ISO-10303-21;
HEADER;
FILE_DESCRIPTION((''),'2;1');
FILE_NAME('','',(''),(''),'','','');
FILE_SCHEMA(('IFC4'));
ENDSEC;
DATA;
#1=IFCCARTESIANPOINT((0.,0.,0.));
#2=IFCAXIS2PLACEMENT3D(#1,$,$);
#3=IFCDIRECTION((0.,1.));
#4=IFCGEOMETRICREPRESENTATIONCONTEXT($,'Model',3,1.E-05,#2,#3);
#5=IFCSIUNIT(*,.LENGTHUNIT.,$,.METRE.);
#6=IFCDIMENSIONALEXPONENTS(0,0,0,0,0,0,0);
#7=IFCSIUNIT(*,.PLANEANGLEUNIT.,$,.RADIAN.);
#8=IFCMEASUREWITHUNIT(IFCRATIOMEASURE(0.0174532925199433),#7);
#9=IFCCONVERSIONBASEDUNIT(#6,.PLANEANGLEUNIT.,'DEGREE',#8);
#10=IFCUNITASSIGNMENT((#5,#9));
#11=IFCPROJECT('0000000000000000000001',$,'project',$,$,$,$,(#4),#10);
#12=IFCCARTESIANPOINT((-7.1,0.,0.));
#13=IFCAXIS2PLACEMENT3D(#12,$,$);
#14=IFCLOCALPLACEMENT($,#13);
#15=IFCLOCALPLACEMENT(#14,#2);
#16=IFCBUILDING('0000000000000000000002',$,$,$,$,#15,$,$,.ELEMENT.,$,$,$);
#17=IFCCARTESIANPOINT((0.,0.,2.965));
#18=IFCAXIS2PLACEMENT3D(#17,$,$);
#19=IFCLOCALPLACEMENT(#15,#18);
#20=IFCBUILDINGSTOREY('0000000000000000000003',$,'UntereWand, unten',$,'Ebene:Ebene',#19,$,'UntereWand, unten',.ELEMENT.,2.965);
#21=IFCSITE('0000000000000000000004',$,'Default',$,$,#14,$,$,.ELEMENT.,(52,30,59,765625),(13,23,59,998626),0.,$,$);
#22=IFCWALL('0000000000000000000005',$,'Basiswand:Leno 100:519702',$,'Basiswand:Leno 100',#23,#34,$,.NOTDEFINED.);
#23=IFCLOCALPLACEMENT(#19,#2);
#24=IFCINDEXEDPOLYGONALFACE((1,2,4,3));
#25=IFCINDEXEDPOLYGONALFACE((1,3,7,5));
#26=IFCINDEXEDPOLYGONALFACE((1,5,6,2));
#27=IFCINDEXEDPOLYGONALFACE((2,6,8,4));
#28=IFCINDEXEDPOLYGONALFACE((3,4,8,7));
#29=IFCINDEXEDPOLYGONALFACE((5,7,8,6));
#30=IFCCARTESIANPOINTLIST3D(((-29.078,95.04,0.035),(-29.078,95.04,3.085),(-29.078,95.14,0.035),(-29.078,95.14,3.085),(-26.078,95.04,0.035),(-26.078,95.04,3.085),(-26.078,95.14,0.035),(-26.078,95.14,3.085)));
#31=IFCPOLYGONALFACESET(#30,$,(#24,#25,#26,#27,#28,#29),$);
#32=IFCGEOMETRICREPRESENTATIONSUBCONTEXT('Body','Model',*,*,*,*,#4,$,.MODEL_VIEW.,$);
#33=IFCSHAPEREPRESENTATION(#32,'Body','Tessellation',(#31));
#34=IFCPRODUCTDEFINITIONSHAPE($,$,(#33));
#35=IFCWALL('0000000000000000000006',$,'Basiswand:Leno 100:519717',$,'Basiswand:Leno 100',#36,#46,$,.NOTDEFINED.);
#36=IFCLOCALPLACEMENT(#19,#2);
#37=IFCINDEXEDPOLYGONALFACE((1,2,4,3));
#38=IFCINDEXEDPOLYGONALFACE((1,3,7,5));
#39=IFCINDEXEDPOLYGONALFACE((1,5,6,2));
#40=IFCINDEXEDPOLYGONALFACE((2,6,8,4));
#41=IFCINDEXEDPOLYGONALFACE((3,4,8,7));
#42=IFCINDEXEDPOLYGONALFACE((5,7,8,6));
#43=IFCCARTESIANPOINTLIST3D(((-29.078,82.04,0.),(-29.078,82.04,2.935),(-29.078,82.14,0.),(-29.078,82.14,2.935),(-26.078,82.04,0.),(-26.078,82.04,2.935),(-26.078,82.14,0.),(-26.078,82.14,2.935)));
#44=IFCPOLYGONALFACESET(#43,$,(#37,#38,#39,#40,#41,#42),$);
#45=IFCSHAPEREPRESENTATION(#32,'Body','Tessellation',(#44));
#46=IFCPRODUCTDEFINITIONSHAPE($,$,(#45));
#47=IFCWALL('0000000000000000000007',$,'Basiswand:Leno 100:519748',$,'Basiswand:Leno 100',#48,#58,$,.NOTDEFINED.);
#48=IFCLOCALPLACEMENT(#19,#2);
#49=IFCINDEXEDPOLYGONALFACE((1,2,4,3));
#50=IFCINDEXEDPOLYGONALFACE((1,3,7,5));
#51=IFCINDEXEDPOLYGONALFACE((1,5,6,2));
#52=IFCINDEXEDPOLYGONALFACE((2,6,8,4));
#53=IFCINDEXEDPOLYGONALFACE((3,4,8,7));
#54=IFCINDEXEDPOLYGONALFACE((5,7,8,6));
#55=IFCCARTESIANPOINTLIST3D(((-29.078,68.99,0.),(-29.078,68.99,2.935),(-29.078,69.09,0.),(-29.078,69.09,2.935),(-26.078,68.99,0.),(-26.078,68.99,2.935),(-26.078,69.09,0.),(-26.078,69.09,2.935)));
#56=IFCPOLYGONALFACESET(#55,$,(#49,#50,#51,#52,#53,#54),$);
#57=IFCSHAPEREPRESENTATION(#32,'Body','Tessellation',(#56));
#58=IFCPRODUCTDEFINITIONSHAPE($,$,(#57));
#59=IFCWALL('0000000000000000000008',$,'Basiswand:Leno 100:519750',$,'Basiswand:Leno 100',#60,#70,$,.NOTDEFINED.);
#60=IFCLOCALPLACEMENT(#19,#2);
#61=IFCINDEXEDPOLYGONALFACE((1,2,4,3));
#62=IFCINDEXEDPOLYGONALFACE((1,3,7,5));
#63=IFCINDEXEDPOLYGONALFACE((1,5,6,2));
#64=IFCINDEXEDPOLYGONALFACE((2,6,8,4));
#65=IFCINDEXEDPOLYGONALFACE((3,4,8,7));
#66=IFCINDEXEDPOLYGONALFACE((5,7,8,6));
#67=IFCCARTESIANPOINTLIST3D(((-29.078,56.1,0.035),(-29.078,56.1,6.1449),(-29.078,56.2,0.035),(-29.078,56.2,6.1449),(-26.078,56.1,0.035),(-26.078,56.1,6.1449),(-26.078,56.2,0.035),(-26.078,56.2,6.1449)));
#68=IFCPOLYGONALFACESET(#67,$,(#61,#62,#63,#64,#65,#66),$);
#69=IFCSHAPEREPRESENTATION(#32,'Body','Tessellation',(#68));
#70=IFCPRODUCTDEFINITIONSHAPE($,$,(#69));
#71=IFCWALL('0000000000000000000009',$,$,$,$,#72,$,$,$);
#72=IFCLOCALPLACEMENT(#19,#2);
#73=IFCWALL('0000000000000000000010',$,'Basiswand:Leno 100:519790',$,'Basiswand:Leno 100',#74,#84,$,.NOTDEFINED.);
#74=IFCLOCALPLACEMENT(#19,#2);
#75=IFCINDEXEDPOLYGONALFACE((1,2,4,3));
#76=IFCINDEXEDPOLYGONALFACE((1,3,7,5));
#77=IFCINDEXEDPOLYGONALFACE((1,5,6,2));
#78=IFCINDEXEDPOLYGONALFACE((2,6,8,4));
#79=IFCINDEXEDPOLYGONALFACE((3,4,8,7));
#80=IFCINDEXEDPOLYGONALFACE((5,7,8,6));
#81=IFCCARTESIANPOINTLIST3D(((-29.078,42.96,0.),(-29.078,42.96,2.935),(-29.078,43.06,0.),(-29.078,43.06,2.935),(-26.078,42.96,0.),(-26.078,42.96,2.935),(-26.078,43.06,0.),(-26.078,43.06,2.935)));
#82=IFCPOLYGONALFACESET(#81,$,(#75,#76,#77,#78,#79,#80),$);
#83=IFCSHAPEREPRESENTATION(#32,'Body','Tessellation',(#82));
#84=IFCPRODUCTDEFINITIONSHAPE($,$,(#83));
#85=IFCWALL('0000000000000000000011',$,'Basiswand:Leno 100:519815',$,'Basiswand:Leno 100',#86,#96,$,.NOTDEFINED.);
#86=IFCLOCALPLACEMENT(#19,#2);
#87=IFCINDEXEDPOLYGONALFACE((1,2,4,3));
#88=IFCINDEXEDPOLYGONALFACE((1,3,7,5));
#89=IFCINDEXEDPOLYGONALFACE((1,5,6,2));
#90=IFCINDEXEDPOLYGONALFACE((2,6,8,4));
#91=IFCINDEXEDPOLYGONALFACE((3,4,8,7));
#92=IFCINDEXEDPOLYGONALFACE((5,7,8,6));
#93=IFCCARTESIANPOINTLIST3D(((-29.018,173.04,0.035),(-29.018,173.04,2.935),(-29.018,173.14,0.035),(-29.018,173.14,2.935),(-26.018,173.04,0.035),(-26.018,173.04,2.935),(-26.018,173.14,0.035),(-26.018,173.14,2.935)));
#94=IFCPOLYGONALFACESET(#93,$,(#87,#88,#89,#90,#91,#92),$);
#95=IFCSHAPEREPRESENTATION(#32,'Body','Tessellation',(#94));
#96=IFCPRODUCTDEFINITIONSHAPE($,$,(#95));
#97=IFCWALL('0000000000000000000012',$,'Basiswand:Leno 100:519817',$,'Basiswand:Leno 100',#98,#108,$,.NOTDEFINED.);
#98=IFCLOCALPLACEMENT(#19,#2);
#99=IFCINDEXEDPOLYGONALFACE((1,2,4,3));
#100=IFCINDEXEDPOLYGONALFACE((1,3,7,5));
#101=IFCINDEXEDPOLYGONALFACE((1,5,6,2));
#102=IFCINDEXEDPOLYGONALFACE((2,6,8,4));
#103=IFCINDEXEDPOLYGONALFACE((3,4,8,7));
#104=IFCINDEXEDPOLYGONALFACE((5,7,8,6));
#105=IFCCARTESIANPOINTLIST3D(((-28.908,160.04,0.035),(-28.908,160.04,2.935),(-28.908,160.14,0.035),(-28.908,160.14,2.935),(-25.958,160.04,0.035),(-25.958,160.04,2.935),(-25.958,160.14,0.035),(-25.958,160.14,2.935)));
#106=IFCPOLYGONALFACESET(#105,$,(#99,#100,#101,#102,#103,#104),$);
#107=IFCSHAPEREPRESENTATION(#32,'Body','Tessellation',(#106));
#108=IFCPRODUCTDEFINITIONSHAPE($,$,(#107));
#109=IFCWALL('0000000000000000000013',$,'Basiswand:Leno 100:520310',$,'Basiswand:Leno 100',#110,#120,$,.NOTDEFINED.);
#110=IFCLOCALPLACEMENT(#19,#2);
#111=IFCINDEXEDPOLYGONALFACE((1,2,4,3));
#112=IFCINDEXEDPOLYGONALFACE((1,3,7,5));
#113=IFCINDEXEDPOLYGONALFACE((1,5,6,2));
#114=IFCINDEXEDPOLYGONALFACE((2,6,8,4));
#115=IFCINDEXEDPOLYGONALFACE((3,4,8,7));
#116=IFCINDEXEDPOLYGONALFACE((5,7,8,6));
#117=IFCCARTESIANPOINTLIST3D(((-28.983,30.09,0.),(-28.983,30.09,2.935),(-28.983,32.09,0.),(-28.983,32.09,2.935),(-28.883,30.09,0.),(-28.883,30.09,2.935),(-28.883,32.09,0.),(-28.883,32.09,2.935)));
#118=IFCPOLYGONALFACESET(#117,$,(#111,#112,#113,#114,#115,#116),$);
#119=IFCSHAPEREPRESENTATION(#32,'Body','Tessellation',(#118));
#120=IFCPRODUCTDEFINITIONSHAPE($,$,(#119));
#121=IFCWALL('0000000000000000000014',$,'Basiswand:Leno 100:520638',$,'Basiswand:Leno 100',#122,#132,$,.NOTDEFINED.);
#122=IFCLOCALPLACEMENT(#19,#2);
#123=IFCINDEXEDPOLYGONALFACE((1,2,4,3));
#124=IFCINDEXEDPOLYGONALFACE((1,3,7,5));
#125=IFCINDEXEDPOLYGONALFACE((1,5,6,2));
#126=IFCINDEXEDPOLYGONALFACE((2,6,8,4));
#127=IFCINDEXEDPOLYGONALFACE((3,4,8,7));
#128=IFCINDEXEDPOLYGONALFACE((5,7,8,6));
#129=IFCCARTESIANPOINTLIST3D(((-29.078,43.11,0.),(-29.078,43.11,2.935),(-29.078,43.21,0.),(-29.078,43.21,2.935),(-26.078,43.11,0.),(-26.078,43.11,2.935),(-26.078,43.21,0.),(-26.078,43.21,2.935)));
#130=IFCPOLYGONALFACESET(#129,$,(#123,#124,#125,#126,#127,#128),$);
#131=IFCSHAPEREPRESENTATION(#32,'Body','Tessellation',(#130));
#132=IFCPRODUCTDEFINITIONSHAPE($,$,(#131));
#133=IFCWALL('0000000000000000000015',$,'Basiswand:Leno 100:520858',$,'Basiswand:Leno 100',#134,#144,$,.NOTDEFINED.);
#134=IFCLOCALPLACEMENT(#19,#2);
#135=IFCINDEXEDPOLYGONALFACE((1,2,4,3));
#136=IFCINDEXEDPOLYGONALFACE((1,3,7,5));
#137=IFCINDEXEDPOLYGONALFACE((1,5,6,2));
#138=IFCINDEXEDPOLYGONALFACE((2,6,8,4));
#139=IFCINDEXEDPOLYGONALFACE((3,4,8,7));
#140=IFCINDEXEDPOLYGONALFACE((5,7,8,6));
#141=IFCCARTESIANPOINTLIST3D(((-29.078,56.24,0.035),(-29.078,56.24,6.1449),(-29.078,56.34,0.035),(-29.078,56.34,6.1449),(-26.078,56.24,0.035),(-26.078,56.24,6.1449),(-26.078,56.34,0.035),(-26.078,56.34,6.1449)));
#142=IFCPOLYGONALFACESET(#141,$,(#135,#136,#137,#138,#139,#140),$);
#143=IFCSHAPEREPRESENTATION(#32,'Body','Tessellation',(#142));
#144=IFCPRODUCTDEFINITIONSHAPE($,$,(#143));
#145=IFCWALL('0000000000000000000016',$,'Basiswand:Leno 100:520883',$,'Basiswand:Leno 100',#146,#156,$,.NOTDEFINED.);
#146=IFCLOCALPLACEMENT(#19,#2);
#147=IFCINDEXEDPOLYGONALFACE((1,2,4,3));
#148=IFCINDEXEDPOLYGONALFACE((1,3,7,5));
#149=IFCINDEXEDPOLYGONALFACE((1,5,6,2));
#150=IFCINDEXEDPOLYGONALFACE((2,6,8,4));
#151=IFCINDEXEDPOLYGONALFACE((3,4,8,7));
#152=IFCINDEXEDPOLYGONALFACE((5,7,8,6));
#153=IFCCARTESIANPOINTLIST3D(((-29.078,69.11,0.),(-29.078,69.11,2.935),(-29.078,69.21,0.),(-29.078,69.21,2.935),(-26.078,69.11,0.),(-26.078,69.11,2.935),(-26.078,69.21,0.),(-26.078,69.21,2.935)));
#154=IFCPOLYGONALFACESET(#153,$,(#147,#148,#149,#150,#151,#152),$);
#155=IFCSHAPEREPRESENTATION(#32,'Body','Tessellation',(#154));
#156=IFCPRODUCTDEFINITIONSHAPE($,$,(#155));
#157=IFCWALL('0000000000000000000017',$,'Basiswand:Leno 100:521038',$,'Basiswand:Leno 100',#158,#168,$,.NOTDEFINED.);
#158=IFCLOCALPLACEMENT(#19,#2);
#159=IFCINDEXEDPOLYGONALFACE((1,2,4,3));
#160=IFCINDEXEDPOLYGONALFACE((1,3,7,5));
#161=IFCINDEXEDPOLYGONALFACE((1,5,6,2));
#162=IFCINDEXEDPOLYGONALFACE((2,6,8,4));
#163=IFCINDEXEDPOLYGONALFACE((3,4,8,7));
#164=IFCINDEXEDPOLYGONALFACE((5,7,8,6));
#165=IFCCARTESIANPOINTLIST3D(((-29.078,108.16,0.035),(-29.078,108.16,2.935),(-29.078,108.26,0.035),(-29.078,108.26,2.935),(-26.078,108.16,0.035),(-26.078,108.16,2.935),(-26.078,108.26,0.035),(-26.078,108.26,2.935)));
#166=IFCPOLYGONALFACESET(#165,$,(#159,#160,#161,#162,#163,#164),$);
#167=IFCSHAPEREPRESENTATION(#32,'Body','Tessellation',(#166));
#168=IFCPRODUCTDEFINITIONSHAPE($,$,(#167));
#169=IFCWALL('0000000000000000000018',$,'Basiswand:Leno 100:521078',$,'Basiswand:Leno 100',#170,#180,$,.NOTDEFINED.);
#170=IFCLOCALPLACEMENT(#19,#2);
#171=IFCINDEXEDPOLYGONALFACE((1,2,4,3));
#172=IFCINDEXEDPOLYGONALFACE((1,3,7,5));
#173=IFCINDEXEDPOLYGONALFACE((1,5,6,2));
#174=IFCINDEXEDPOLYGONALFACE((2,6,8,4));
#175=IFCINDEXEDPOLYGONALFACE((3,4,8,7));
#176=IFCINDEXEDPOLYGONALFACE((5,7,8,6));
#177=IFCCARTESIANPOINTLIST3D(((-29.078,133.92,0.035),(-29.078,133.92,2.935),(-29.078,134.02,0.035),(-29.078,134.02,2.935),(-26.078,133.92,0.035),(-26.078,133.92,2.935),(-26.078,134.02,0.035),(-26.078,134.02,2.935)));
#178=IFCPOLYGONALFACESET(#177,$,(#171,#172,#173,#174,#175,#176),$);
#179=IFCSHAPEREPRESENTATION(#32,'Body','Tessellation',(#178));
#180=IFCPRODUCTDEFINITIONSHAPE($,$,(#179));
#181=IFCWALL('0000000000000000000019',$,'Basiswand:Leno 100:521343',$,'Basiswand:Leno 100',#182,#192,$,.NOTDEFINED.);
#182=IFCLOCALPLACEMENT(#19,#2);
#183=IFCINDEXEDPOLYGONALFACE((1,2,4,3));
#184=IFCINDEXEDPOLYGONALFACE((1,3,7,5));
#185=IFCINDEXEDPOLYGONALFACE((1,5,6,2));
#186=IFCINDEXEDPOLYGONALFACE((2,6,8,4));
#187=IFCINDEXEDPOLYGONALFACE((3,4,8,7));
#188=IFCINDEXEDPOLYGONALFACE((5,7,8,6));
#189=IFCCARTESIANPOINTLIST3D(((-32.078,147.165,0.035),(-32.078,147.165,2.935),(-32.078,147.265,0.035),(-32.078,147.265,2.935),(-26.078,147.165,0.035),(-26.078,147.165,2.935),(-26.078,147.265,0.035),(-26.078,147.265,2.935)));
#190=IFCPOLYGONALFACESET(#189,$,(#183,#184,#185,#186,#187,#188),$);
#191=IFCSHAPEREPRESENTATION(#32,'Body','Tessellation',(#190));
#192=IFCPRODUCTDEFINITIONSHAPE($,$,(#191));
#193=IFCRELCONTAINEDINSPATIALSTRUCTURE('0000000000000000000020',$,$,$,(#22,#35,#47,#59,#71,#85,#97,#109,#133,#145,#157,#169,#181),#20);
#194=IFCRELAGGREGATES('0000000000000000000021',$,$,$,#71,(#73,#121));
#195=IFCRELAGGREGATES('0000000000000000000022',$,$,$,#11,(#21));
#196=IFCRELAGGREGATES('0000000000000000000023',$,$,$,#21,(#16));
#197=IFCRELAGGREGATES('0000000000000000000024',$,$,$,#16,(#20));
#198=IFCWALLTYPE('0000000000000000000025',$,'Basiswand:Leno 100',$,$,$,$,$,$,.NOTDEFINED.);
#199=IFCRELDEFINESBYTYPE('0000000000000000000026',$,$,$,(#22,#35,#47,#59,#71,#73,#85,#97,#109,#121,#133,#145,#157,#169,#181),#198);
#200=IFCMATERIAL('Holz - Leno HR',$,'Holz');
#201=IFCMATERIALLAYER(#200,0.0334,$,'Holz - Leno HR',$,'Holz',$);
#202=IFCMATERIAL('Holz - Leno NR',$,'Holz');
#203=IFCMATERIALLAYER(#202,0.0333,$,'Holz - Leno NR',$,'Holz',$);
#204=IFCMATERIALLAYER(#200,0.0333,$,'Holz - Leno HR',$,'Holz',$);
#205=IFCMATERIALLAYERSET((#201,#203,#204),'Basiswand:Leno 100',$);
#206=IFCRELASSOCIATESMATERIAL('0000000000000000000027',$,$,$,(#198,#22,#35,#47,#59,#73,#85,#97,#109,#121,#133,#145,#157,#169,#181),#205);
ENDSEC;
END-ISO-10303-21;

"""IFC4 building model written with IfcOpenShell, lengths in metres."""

from ifc_helpers import new_model, entity, si_unit, converted_unit, direction, frame, origin, place, context, subcontext, project, spatial, indexed_curve, outline, extrude, material, layer, layer_set, type_object, element, aggregate, save


model = new_model("IFC4")

# Units and contexts
model_context = context("Model", 3, precision=1e-05, world=origin(), true_north=direction((0.0, 1.0)))
body_context = subcontext(model_context, "Body", "Model", "MODEL_VIEW")
ifc_project = project(units=[si_unit("LENGTHUNIT", "METRE"), converted_unit("PLANEANGLEUNIT", "DEGREE", entity("IfcRatioMeasure", 0.0174532925199433), si_unit("PLANEANGLEUNIT", "RADIAN"), dimensions=[0, 0, 0, 0, 0, 0, 0])], contexts=[model_context])

# Site, building, storey
site_placement = place(None, frame((-7.1, 0.0, 0.0)))
site = spatial("IfcSite", under=ifc_project, at=site_placement, Name="Default", CompositionType="ELEMENT", RefLatitude=(52, 30, 59, 765625), RefLongitude=(13, 23, 59, 998626), RefElevation=0.0)
building_placement = place(site_placement, origin())
building = spatial("IfcBuilding", under=site, at=building_placement, CompositionType="ELEMENT")
storey_placement = place(building_placement, frame((0.0, 0.0, 2.965)))
storey = spatial("IfcBuildingStorey", under=building, at=storey_placement, Name="UntereWand, unten", ObjectType="Ebene:Ebene", LongName="UntereWand, unten", CompositionType="ELEMENT", Elevation=2.965)

# Walls
ifc_material_1 = material(Name="Holz - Leno HR", Category="Holz")
ifc_layer_1 = layer(ifc_material_1, 0.0334, Name="Holz - Leno HR", Category="Holz")
ifc_material_2 = material(Name="Holz - Leno NR", Category="Holz")
ifc_layer_2 = layer(ifc_material_2, 0.0333, Name="Holz - Leno NR", Category="Holz")
ifc_layer_3 = layer(ifc_material_1, 0.0333, Name="Holz - Leno HR", Category="Holz")
ifc_layer_set = layer_set([ifc_layer_1, ifc_layer_2, ifc_layer_3], Name="Basiswand:Leno 100")
wall_type = type_object("IfcWallType", Name="Basiswand:Leno 100", PredefinedType="NOTDEFINED", material=ifc_layer_set)
wall_1_placement = place(storey_placement, frame((-26.078, 95.09, 0.035), z_axis=(0.0, 0.0, 1.0), x_axis=(-1.0, 0.0, 0.0)))
element("IfcWall", 1, at=wall_1_placement, inside=storey, type_object=wall_type, material=ifc_layer_set, Name="Basiswand:Leno 100:519702", ObjectType="Basiswand:Leno 100", PredefinedType="NOTDEFINED", context=body_context, shape_type="SweptSolid", body=[
    extrude(outline(indexed_curve([(3.0, 0.05), (0.0, 0.05), (0.0, -0.05), (3.0, -0.05), (3.0, 0.05)], self_intersect=False)), origin(), (0.0, 0.0, 1.0), 3.05),
])
wall_2_placement = place(storey_placement, frame((-26.078, 82.09, 0.0), z_axis=(0.0, 0.0, 1.0), x_axis=(-1.0, 0.0, 0.0)))
element("IfcWall", 2, at=wall_2_placement, inside=storey, type_object=wall_type, material=ifc_layer_set, Name="Basiswand:Leno 100:519717", ObjectType="Basiswand:Leno 100", PredefinedType="NOTDEFINED", context=body_context, shape_type="SweptSolid", body=[
    extrude(outline(indexed_curve([(3.0, 0.05), (0.0, 0.05), (0.0, -0.05), (3.0, -0.05), (3.0, 0.05)], self_intersect=False)), origin(), (0.0, 0.0, 1.0), 2.935),
])
wall_3_placement = place(storey_placement, frame((-26.078, 69.04, 0.0), z_axis=(0.0, 0.0, 1.0), x_axis=(-1.0, 0.0, 0.0)))
element("IfcWall", 3, at=wall_3_placement, inside=storey, type_object=wall_type, material=ifc_layer_set, Name="Basiswand:Leno 100:519748", ObjectType="Basiswand:Leno 100", PredefinedType="NOTDEFINED", context=body_context, shape_type="SweptSolid", body=[
    extrude(outline(indexed_curve([(3.0, 0.05), (0.0, 0.05), (0.0, -0.05), (3.0, -0.05), (3.0, 0.05)], self_intersect=False)), origin(), (0.0, 0.0, 1.0), 2.935),
])
wall_4_placement = place(storey_placement, frame((-26.078, 56.15, 0.035), z_axis=(0.0, 0.0, 1.0), x_axis=(-1.0, 0.0, 0.0)))
element("IfcWall", 4, at=wall_4_placement, inside=storey, type_object=wall_type, material=ifc_layer_set, Name="Basiswand:Leno 100:519750", ObjectType="Basiswand:Leno 100", PredefinedType="NOTDEFINED", context=body_context, shape_type="SweptSolid", body=[
    extrude(outline(indexed_curve([(3.0, 0.05), (0.0, 0.05), (0.0, -0.05), (3.0, -0.05), (3.0, 0.05)], self_intersect=False)), origin(), (0.0, 0.0, 1.0), 6.1099),
])
wall_5 = element("IfcWall", 5, inside=storey, type_object=wall_type)
wall_6_placement = place(storey_placement, frame((-26.078, 43.01, 0.0), z_axis=(0.0, 0.0, 1.0), x_axis=(-1.0, 0.0, 0.0)))
wall_6 = element("IfcWall", 6, at=wall_6_placement, type_object=wall_type, material=ifc_layer_set, Name="Basiswand:Leno 100:519790", ObjectType="Basiswand:Leno 100", PredefinedType="NOTDEFINED", context=body_context, shape_type="SweptSolid", body=[
    extrude(outline(indexed_curve([(3.0, 0.05), (0.0, 0.05), (0.0, -0.05), (3.0, -0.05), (3.0, 0.05)], self_intersect=False)), origin(), (0.0, 0.0, 1.0), 2.935),
])
wall_7_placement = place(storey_placement, frame((-29.018, 173.09, 0.035)))
element("IfcWall", 7, at=wall_7_placement, inside=storey, type_object=wall_type, material=ifc_layer_set, Name="Basiswand:Leno 100:519815", ObjectType="Basiswand:Leno 100", PredefinedType="NOTDEFINED", context=body_context, shape_type="SweptSolid", body=[
    extrude(outline(indexed_curve([(3.0, 0.05), (0.0, 0.05), (0.0, -0.05), (3.0, -0.05), (3.0, 0.05)], self_intersect=False)), origin(), (0.0, 0.0, 1.0), 2.9),
])
wall_8_placement = place(storey_placement, frame((-25.958, 160.09, 0.035), z_axis=(0.0, 0.0, 1.0), x_axis=(-1.0, 0.0, 0.0)))
element("IfcWall", 8, at=wall_8_placement, inside=storey, type_object=wall_type, material=ifc_layer_set, Name="Basiswand:Leno 100:519817", ObjectType="Basiswand:Leno 100", PredefinedType="NOTDEFINED", context=body_context, shape_type="SweptSolid", body=[
    extrude(outline(indexed_curve([(2.95, 0.05), (0.0, 0.05), (0.0, -0.05), (2.95, -0.05), (2.95, 0.05)], self_intersect=False)), origin(), (0.0, 0.0, 1.0), 2.9),
])
wall_9_placement = place(storey_placement, frame((-28.933, 32.09, 0.0), z_axis=(0.0, 0.0, 1.0), x_axis=(0.0, -1.0, 0.0)))
element("IfcWall", 9, at=wall_9_placement, inside=storey, type_object=wall_type, material=ifc_layer_set, Name="Basiswand:Leno 100:520310", ObjectType="Basiswand:Leno 100", PredefinedType="NOTDEFINED", context=body_context, shape_type="SweptSolid", body=[
    extrude(outline(indexed_curve([(2.0, 0.05), (0.0, 0.05), (0.0, -0.05), (2.0, -0.05), (2.0, 0.05)], self_intersect=False)), origin(), (0.0, 0.0, 1.0), 2.935),
])

# Wall
wall_10_placement = place(storey_placement, frame((-26.078, 43.16, 0.0), z_axis=(0.0, 0.0, 1.0), x_axis=(-1.0, 0.0, 0.0)))
wall_10 = element("IfcWall", 10, at=wall_10_placement, type_object=wall_type, material=ifc_layer_set, Name="Basiswand:Leno 100:520638", ObjectType="Basiswand:Leno 100", PredefinedType="NOTDEFINED", context=body_context, shape_type="SweptSolid", body=[
    extrude(outline(indexed_curve([(3.0, 0.05), (0.0, 0.05), (0.0, -0.05), (3.0, -0.05), (3.0, 0.05)], self_intersect=False)), origin(), (0.0, 0.0, 1.0), 2.935),
])
aggregate(wall_5, [wall_6, wall_10])

# Walls
wall_11_placement = place(storey_placement, frame((-26.078, 56.29, 0.035), z_axis=(0.0, 0.0, 1.0), x_axis=(-1.0, 0.0, 0.0)))
element("IfcWall", 11, at=wall_11_placement, inside=storey, type_object=wall_type, material=ifc_layer_set, Name="Basiswand:Leno 100:520858", ObjectType="Basiswand:Leno 100", PredefinedType="NOTDEFINED", context=body_context, shape_type="SweptSolid", body=[
    extrude(outline(indexed_curve([(3.0, 0.05), (0.0, 0.05), (0.0, -0.05), (3.0, -0.05), (3.0, 0.05)], self_intersect=False)), origin(), (0.0, 0.0, 1.0), 6.1099),
])
wall_12_placement = place(storey_placement, frame((-26.078, 69.16, 0.0), z_axis=(0.0, 0.0, 1.0), x_axis=(-1.0, 0.0, 0.0)))
element("IfcWall", 12, at=wall_12_placement, inside=storey, type_object=wall_type, material=ifc_layer_set, Name="Basiswand:Leno 100:520883", ObjectType="Basiswand:Leno 100", PredefinedType="NOTDEFINED", context=body_context, shape_type="SweptSolid", body=[
    extrude(outline(indexed_curve([(3.0, 0.05), (0.0, 0.05), (0.0, -0.05), (3.0, -0.05), (3.0, 0.05)], self_intersect=False)), origin(), (0.0, 0.0, 1.0), 2.935),
])
for number, where, z_axis, x_axis, name in (
    (13, (-26.078, 108.21, 0.035), (0.0, 0.0, 1.0), (-1.0, 0.0, 0.0), "Basiswand:Leno 100:521038"),
    (14, (-26.078, 133.97, 0.035), (0.0, 0.0, 1.0), (-1.0, 0.0, 0.0), "Basiswand:Leno 100:521078"),
):
    element("IfcWall", number, at=place(storey_placement, frame(where, z_axis=z_axis, x_axis=x_axis)), inside=storey, type_object=wall_type, material=ifc_layer_set, Name=name, ObjectType="Basiswand:Leno 100", PredefinedType="NOTDEFINED", context=body_context, shape_type="SweptSolid", body=[
        extrude(outline(indexed_curve([(3.0, 0.05), (0.0, 0.05), (0.0, -0.05), (3.0, -0.05), (3.0, 0.05)], self_intersect=False)), origin(), (0.0, 0.0, 1.0), 2.9),
    ])
wall_13_placement = place(storey_placement, frame((-32.078, 147.215, 0.035)))
element("IfcWall", 15, at=wall_13_placement, inside=storey, type_object=wall_type, material=ifc_layer_set, Name="Basiswand:Leno 100:521343", ObjectType="Basiswand:Leno 100", PredefinedType="NOTDEFINED", context=body_context, shape_type="SweptSolid", body=[
    extrude(outline(indexed_curve([(6.0, 0.05), (0.0, 0.05), (0.0, -0.05), (6.0, -0.05), (6.0, 0.05)], self_intersect=False)), origin(), (0.0, 0.0, 1.0), 2.9),
])

save(model, "model.ifc")
